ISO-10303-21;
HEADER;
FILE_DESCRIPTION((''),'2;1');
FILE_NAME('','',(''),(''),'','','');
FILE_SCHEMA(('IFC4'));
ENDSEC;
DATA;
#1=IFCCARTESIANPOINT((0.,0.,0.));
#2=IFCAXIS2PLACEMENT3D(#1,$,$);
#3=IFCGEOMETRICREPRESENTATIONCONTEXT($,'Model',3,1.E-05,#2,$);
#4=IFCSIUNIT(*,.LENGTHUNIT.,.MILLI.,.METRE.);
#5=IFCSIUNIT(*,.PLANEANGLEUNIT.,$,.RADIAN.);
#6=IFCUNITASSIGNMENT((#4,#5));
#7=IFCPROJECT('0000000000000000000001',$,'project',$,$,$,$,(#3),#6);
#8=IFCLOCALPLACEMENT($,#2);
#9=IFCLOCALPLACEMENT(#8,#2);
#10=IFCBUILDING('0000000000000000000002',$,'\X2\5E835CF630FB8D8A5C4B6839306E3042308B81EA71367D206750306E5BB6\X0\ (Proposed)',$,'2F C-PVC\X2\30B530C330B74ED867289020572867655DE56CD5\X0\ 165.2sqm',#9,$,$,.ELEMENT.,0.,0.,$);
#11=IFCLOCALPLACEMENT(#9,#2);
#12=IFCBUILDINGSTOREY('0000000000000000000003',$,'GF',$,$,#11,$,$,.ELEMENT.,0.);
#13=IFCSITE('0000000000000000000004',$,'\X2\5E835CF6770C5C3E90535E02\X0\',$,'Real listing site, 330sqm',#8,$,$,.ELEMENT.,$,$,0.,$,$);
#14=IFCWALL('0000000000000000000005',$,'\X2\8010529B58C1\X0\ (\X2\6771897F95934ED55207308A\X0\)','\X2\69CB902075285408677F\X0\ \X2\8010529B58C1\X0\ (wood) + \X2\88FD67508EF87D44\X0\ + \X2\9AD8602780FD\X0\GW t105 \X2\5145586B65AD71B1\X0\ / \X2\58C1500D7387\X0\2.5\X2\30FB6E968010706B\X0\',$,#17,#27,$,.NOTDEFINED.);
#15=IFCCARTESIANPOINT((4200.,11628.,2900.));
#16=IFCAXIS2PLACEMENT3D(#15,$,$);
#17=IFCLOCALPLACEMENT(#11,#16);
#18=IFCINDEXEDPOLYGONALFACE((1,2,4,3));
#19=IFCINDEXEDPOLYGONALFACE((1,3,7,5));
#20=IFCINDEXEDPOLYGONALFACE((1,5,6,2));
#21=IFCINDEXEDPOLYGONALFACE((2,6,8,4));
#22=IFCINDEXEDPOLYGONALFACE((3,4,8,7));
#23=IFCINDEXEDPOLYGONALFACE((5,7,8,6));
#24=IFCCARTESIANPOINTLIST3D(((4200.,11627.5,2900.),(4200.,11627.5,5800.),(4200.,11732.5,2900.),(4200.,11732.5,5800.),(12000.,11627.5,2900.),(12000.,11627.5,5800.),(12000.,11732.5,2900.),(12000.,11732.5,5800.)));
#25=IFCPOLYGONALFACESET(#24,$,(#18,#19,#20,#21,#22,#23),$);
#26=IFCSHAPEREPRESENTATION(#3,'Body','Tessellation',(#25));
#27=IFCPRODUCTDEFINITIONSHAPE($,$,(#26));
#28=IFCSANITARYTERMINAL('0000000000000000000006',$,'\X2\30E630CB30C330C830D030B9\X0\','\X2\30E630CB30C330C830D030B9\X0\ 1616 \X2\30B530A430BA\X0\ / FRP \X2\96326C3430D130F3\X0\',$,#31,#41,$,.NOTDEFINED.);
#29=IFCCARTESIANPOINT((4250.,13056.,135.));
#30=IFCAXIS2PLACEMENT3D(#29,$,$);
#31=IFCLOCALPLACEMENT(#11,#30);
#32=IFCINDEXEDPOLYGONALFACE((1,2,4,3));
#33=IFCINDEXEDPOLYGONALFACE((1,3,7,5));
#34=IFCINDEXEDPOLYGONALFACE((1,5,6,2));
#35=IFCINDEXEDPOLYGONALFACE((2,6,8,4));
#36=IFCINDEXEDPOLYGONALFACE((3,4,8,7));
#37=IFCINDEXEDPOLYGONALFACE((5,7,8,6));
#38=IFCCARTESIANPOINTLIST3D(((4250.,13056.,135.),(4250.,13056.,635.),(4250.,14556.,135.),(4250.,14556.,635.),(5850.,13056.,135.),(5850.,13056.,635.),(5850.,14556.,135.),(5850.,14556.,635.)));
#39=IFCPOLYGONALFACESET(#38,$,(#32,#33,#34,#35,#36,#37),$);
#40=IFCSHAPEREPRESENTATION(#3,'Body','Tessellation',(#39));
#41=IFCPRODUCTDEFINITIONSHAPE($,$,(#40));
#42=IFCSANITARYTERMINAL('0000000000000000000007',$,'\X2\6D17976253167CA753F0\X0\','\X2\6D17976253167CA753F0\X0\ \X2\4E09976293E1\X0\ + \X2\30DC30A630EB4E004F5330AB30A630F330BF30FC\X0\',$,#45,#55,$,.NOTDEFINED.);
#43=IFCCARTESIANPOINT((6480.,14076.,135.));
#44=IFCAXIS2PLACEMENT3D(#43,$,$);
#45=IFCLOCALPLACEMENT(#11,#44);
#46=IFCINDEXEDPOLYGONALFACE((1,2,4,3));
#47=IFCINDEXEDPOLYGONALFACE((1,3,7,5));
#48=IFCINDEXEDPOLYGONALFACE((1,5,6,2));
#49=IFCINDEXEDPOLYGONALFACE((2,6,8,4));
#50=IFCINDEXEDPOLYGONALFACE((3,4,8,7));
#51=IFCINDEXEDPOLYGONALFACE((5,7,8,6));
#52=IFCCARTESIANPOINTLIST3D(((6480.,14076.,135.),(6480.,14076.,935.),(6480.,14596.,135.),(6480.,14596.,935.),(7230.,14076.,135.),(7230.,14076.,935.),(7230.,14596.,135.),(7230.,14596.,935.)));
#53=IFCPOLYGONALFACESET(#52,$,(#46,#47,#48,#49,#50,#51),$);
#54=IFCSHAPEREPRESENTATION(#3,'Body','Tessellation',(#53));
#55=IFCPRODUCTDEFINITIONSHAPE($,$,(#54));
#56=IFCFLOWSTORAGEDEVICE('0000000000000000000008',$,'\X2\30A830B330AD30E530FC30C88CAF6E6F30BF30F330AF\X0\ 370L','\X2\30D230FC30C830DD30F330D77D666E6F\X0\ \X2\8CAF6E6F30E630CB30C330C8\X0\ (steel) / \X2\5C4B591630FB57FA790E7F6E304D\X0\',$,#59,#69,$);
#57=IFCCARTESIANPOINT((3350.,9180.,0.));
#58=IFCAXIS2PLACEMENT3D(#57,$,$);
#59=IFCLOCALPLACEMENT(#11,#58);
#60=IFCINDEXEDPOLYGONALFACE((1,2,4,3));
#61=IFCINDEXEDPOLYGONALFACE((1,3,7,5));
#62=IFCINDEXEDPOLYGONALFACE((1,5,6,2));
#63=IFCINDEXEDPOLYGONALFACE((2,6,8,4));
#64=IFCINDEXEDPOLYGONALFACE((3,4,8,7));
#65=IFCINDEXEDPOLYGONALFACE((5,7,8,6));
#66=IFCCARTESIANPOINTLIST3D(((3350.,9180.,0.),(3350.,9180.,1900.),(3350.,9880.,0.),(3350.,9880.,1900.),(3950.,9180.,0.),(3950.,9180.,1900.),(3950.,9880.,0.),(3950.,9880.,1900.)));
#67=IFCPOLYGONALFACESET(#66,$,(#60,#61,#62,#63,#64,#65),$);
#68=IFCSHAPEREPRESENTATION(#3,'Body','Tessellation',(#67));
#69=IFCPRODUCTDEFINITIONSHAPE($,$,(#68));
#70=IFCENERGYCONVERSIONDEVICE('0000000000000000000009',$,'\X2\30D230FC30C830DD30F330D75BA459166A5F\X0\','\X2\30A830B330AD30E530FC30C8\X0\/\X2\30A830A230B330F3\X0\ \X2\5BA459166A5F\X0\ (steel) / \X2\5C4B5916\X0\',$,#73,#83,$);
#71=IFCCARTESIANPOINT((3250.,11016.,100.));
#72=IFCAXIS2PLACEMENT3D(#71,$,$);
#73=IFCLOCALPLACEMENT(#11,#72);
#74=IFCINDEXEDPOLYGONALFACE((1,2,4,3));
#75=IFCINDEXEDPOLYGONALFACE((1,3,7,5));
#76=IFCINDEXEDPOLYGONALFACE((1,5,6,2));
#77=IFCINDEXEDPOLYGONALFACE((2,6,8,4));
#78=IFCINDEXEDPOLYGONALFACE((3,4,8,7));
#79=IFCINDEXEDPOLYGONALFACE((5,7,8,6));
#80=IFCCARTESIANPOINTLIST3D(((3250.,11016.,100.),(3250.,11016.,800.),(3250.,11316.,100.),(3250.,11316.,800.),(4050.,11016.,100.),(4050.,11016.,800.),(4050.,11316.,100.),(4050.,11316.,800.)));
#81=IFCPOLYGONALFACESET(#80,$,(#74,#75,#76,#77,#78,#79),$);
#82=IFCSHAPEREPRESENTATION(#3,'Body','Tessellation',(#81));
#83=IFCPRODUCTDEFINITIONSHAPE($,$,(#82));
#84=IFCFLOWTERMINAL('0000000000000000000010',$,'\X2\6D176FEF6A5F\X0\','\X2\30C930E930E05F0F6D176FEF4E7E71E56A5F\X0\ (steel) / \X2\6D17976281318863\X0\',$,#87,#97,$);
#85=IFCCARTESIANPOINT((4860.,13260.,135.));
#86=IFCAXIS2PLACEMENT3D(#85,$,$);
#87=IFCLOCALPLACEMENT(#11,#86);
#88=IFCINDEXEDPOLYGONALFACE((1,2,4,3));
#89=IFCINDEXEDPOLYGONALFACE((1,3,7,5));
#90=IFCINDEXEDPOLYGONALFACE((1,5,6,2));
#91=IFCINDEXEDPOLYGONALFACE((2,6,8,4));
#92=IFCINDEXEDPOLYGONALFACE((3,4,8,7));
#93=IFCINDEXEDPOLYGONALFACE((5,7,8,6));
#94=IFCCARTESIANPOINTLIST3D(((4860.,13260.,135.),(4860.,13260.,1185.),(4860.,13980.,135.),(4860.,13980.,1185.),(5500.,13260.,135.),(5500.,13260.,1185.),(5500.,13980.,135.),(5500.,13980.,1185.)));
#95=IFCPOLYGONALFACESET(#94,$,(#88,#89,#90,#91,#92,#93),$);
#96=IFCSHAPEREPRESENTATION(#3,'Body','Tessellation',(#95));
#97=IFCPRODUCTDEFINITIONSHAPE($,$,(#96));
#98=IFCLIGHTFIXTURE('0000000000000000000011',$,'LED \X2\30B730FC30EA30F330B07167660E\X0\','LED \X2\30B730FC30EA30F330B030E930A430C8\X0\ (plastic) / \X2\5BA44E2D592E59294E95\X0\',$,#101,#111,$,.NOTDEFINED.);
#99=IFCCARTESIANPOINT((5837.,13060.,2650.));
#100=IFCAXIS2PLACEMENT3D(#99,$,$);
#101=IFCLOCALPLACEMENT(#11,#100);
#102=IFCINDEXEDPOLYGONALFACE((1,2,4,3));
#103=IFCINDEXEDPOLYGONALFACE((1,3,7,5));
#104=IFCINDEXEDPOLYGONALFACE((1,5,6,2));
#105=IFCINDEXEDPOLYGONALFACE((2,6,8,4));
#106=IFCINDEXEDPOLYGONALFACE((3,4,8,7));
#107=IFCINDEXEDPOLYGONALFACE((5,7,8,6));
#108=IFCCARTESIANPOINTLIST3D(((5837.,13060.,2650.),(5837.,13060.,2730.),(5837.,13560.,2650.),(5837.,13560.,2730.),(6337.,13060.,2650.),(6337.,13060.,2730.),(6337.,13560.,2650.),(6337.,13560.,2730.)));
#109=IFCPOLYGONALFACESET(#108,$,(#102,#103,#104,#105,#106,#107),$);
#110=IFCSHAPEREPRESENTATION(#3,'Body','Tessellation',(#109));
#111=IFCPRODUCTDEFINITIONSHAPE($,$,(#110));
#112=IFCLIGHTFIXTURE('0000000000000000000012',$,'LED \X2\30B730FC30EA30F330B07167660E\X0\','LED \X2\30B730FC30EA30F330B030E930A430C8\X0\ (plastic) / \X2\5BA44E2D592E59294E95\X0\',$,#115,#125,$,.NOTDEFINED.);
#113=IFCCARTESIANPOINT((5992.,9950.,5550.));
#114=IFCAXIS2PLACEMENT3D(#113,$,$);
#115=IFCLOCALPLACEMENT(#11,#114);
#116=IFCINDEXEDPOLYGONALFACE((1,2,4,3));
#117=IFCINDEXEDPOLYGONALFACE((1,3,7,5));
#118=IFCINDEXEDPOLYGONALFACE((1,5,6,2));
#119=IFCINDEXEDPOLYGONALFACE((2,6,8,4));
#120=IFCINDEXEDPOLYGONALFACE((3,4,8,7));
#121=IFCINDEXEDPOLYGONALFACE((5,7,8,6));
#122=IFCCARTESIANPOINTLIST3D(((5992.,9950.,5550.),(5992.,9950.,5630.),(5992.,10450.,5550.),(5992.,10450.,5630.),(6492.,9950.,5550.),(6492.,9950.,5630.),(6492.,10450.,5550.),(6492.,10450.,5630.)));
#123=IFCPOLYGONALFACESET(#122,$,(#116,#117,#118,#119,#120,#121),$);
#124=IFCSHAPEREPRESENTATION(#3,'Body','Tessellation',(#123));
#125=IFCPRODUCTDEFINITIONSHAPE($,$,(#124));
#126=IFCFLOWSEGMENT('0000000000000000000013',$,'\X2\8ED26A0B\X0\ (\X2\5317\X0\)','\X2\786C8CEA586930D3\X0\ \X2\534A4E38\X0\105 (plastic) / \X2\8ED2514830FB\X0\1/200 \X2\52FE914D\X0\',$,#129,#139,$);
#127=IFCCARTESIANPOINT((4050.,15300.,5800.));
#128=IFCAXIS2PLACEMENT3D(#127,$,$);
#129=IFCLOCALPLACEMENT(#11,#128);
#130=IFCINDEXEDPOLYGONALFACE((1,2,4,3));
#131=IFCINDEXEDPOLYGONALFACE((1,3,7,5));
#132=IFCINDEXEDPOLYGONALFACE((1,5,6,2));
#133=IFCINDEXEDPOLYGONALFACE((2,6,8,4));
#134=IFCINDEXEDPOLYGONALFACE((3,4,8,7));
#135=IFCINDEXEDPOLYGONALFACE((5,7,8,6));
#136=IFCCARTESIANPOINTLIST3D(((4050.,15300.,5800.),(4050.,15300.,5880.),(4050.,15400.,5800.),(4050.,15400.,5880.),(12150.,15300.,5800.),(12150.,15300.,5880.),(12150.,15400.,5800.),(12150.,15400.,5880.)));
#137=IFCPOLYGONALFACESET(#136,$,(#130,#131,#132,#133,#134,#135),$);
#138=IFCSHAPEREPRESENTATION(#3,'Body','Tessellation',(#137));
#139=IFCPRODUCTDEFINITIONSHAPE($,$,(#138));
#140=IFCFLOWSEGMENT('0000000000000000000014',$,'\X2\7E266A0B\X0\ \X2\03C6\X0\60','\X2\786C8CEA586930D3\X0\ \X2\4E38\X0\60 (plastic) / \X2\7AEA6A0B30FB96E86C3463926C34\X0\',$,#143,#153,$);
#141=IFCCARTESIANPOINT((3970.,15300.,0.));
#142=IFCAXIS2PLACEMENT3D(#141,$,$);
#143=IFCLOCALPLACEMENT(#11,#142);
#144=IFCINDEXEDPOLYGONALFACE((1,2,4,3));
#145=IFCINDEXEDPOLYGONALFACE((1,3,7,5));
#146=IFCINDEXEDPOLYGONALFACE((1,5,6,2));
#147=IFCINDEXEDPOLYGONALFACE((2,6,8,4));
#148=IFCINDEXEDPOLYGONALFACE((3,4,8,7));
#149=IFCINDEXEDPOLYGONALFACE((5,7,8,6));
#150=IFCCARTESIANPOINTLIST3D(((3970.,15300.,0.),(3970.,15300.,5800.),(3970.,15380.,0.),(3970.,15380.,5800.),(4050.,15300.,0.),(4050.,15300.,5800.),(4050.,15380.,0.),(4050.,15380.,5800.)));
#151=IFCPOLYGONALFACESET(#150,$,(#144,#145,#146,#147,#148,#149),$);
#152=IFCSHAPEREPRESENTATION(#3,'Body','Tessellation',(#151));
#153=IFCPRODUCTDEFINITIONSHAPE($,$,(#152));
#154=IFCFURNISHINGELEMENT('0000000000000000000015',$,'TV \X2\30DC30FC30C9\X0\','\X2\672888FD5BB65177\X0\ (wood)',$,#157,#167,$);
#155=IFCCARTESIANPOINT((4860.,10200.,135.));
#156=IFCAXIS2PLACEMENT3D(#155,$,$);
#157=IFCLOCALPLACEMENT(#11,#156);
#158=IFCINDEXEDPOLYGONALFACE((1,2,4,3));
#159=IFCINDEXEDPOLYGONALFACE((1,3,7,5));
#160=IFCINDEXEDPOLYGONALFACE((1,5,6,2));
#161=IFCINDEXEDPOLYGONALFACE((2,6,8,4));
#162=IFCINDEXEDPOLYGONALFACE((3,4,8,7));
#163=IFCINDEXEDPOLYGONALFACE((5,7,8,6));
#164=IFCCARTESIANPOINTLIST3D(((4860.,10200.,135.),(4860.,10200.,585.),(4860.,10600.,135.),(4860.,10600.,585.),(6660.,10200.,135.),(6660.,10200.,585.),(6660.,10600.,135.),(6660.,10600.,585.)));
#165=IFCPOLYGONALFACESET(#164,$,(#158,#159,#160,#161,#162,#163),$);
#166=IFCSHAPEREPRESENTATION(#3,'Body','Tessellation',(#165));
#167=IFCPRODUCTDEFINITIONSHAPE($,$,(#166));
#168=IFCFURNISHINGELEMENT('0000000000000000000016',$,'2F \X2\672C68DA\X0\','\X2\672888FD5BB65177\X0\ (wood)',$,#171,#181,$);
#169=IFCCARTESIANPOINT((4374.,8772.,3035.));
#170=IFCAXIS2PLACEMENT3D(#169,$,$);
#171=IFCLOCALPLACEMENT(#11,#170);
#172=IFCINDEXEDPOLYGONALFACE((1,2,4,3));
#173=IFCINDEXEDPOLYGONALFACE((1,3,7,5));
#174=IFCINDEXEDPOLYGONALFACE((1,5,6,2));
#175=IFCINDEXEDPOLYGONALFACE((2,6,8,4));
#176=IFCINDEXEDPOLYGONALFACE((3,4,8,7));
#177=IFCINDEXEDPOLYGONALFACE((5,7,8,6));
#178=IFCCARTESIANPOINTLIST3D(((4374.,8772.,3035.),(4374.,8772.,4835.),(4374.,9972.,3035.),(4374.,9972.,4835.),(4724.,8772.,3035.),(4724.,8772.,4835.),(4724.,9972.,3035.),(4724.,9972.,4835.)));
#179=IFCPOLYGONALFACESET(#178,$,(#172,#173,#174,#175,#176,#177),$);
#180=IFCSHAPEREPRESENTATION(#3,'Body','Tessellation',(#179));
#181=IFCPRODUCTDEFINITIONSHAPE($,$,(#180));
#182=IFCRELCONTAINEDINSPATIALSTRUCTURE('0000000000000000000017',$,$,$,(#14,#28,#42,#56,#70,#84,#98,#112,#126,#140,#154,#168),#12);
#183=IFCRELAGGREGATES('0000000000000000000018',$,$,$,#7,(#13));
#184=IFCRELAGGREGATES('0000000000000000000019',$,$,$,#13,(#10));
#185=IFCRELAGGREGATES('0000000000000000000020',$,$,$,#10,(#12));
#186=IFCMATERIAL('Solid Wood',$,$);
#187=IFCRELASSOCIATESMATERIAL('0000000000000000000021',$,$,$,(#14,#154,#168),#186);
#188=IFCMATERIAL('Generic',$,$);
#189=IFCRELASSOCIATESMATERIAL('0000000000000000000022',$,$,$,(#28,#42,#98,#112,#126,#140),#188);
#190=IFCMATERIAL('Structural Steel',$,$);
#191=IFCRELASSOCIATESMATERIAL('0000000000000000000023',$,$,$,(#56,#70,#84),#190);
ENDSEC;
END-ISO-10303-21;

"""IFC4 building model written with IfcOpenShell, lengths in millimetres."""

from ifc_helpers import new_model, si_unit, frame, frame_2d, origin, place, context, project, spatial, rectangle, extrude, material, element, save


model = new_model("IFC4")

# Units and contexts
model_context = context("Model", 3, precision=1e-05, world=origin())
ifc_project = project(units=[si_unit("LENGTHUNIT", "METRE", prefix="MILLI"), si_unit("PLANEANGLEUNIT", "RADIAN")], contexts=[model_context])

# Site, building, storey
site_placement = place(None, origin())
site = spatial("IfcSite", under=ifc_project, at=site_placement, Name="広島県尾道市", ObjectType="Real listing site, 330sqm", CompositionType="ELEMENT", RefElevation=0.0)
building_placement = place(site_placement, origin())
building = spatial("IfcBuilding", under=site, at=building_placement, Name="広島・越屋根のある自然素材の家 (Proposed)", ObjectType="2F C-PVCサッシ付木造在来工法 165.2sqm", CompositionType="ELEMENT", ElevationOfRefHeight=0.0, ElevationOfTerrain=0.0)
storey_placement = place(building_placement, origin())
storey = spatial("IfcBuildingStorey", under=building, at=storey_placement, Name="GF", CompositionType="ELEMENT", Elevation=0.0)

# Shared definitions
ifc_material_1 = material(Name="Solid Wood")

# Wall
wall_1_placement = place(storey_placement, frame((4200.0, 11628.0, 2900.0)))
element("IfcWall", 1, at=wall_1_placement, inside=storey, material=ifc_material_1, Name="耐力壁 (東西間仕切り)", Description="構造用合板 耐力壁 (wood) + 製材軸組 + 高性能GW t105 充填断熱 / 壁倍率2.5・準耐火", PredefinedType="NOTDEFINED", context=model_context, shape_type="SweptSolid", body=[
    extrude(rectangle(XDim=7800.0, YDim=105.0, at=frame_2d((3900.0, 52.0))), frame((4200.0, 11628.0, 2900.0)), (0.0, 0.0, 1.0), 2900.0),
])

# Sanitary terminals
ifc_material_2 = material(Name="Generic")
sanitary_terminal_1_placement = place(storey_placement, frame((4250.0, 13056.0, 135.0)))
element("IfcSanitaryTerminal", 2, at=sanitary_terminal_1_placement, inside=storey, material=ifc_material_2, Name="ユニットバス", Description="ユニットバス 1616 サイズ / FRP 防水パン", PredefinedType="NOTDEFINED", context=model_context, shape_type="SweptSolid", body=[
    extrude(rectangle(XDim=1600.0, YDim=1500.0, at=frame_2d((800.0, 750.0))), frame((4250.0, 13056.0, 135.0)), (0.0, 0.0, 1.0), 500.0),
])
sanitary_terminal_2_placement = place(storey_placement, frame((6480.0, 14076.0, 135.0)))
element("IfcSanitaryTerminal", 3, at=sanitary_terminal_2_placement, inside=storey, material=ifc_material_2, Name="洗面化粧台", Description="洗面化粧台 三面鏡 + ボウル一体カウンター", PredefinedType="NOTDEFINED", context=model_context, shape_type="SweptSolid", body=[
    extrude(rectangle(XDim=750.0, YDim=520.0, at=frame_2d((375.0, 260.0))), frame((6480.0, 14076.0, 135.0)), (0.0, 0.0, 1.0), 800.0),
])

# Flow storage device
ifc_material_3 = material(Name="Structural Steel")
flow_storage_device_placement = place(storey_placement, frame((3350.0, 9180.0, 0.0)))
element("IfcFlowStorageDevice", 4, at=flow_storage_device_placement, inside=storey, material=ifc_material_3, Name="エコキュート貯湯タンク 370L", Description="ヒートポンプ給湯 貯湯ユニット (steel) / 屋外・基礎置き", context=model_context, shape_type="SweptSolid", body=[
    extrude(rectangle(XDim=600.0, YDim=700.0, at=frame_2d((300.0, 350.0))), frame((3350.0, 9180.0, 0.0)), (0.0, 0.0, 1.0), 1900.0),
])

# Energy conversion device
energy_conversion_device_placement = place(storey_placement, frame((3250.0, 11016.0, 100.0)))
element("IfcEnergyConversionDevice", 5, at=energy_conversion_device_placement, inside=storey, material=ifc_material_3, Name="ヒートポンプ室外機", Description="エコキュート/エアコン 室外機 (steel) / 屋外", context=model_context, shape_type="SweptSolid", body=[
    extrude(rectangle(XDim=800.0, YDim=300.0, at=frame_2d((400.0, 150.0))), frame((3250.0, 11016.0, 100.0)), (0.0, 0.0, 1.0), 700.0),
])

# Flow terminal
flow_terminal_placement = place(storey_placement, frame((4860.0, 13260.0, 135.0)))
element("IfcFlowTerminal", 6, at=flow_terminal_placement, inside=storey, material=ifc_material_3, Name="洗濯機", Description="ドラム式洗濯乾燥機 (steel) / 洗面脱衣", context=model_context, shape_type="SweptSolid", body=[
    extrude(rectangle(XDim=640.0, YDim=720.0, at=frame_2d((320.0, 360.0))), frame((4860.0, 13260.0, 135.0)), (0.0, 0.0, 1.0), 1050.0),
])

# Light fixtures
light_fixture_1_placement = place(storey_placement, frame((5837.0, 13060.0, 2650.0)))
element("IfcLightFixture", 7, at=light_fixture_1_placement, inside=storey, material=ifc_material_2, Name="LED シーリング照明", Description="LED シーリングライト (plastic) / 室中央天井", PredefinedType="NOTDEFINED", context=model_context, shape_type="SweptSolid", body=[
    extrude(rectangle(XDim=500.0, YDim=500.0, at=frame_2d((250.0, 250.0))), frame((5837.0, 13060.0, 2650.0)), (0.0, 0.0, 1.0), 80.0),
])
light_fixture_2_placement = place(storey_placement, frame((5992.0, 9950.0, 5550.0)))
element("IfcLightFixture", 8, at=light_fixture_2_placement, inside=storey, material=ifc_material_2, Name="LED シーリング照明", Description="LED シーリングライト (plastic) / 室中央天井", PredefinedType="NOTDEFINED", context=model_context, shape_type="SweptSolid", body=[
    extrude(rectangle(XDim=500.0, YDim=500.0, at=frame_2d((250.0, 250.0))), frame((5992.0, 9950.0, 5550.0)), (0.0, 0.0, 1.0), 80.0),
])

# Flow segments
flow_segment_1_placement = place(storey_placement, frame((4050.0, 15300.0, 5800.0)))
element("IfcFlowSegment", 9, at=flow_segment_1_placement, inside=storey, material=ifc_material_2, Name="軒樋 (北)", Description="硬質塩ビ 半丸105 (plastic) / 軒先・1/200 勾配", context=model_context, shape_type="SweptSolid", body=[
    extrude(rectangle(XDim=8100.0, YDim=100.0, at=frame_2d((4050.0, 50.0))), frame((4050.0, 15300.0, 5800.0)), (0.0, 0.0, 1.0), 80.0),
])
flow_segment_2_placement = place(storey_placement, frame((3970.0, 15300.0, 0.0)))
element("IfcFlowSegment", 10, at=flow_segment_2_placement, inside=storey, material=ifc_material_2, Name="縦樋 φ60", Description="硬質塩ビ 丸60 (plastic) / 竪樋・雨水排水", context=model_context, shape_type="SweptSolid", body=[
    extrude(rectangle(XDim=80.0, YDim=80.0, at=frame_2d((40.0, 40.0))), frame((3970.0, 15300.0, 0.0)), (0.0, 0.0, 1.0), 5800.0),
])

# Furnishing elements
furnishing_1_placement = place(storey_placement, frame((4860.0, 10200.0, 135.0)))
element("IfcFurnishingElement", 11, at=furnishing_1_placement, inside=storey, material=ifc_material_1, Name="TV ボード", Description="木製家具 (wood)", context=model_context, shape_type="SweptSolid", body=[
    extrude(rectangle(XDim=1800.0, YDim=400.0, at=frame_2d((900.0, 200.0))), frame((4860.0, 10200.0, 135.0)), (0.0, 0.0, 1.0), 450.0),
])
furnishing_2_placement = place(storey_placement, frame((4374.0, 8772.0, 3035.0)))
element("IfcFurnishingElement", 12, at=furnishing_2_placement, inside=storey, material=ifc_material_1, Name="2F 本棚", Description="木製家具 (wood)", context=model_context, shape_type="SweptSolid", body=[
    extrude(rectangle(XDim=350.0, YDim=1200.0, at=frame_2d((175.0, 600.0))), frame((4374.0, 8772.0, 3035.0)), (0.0, 0.0, 1.0), 1800.0),
])

save(model, "model.ifc")
